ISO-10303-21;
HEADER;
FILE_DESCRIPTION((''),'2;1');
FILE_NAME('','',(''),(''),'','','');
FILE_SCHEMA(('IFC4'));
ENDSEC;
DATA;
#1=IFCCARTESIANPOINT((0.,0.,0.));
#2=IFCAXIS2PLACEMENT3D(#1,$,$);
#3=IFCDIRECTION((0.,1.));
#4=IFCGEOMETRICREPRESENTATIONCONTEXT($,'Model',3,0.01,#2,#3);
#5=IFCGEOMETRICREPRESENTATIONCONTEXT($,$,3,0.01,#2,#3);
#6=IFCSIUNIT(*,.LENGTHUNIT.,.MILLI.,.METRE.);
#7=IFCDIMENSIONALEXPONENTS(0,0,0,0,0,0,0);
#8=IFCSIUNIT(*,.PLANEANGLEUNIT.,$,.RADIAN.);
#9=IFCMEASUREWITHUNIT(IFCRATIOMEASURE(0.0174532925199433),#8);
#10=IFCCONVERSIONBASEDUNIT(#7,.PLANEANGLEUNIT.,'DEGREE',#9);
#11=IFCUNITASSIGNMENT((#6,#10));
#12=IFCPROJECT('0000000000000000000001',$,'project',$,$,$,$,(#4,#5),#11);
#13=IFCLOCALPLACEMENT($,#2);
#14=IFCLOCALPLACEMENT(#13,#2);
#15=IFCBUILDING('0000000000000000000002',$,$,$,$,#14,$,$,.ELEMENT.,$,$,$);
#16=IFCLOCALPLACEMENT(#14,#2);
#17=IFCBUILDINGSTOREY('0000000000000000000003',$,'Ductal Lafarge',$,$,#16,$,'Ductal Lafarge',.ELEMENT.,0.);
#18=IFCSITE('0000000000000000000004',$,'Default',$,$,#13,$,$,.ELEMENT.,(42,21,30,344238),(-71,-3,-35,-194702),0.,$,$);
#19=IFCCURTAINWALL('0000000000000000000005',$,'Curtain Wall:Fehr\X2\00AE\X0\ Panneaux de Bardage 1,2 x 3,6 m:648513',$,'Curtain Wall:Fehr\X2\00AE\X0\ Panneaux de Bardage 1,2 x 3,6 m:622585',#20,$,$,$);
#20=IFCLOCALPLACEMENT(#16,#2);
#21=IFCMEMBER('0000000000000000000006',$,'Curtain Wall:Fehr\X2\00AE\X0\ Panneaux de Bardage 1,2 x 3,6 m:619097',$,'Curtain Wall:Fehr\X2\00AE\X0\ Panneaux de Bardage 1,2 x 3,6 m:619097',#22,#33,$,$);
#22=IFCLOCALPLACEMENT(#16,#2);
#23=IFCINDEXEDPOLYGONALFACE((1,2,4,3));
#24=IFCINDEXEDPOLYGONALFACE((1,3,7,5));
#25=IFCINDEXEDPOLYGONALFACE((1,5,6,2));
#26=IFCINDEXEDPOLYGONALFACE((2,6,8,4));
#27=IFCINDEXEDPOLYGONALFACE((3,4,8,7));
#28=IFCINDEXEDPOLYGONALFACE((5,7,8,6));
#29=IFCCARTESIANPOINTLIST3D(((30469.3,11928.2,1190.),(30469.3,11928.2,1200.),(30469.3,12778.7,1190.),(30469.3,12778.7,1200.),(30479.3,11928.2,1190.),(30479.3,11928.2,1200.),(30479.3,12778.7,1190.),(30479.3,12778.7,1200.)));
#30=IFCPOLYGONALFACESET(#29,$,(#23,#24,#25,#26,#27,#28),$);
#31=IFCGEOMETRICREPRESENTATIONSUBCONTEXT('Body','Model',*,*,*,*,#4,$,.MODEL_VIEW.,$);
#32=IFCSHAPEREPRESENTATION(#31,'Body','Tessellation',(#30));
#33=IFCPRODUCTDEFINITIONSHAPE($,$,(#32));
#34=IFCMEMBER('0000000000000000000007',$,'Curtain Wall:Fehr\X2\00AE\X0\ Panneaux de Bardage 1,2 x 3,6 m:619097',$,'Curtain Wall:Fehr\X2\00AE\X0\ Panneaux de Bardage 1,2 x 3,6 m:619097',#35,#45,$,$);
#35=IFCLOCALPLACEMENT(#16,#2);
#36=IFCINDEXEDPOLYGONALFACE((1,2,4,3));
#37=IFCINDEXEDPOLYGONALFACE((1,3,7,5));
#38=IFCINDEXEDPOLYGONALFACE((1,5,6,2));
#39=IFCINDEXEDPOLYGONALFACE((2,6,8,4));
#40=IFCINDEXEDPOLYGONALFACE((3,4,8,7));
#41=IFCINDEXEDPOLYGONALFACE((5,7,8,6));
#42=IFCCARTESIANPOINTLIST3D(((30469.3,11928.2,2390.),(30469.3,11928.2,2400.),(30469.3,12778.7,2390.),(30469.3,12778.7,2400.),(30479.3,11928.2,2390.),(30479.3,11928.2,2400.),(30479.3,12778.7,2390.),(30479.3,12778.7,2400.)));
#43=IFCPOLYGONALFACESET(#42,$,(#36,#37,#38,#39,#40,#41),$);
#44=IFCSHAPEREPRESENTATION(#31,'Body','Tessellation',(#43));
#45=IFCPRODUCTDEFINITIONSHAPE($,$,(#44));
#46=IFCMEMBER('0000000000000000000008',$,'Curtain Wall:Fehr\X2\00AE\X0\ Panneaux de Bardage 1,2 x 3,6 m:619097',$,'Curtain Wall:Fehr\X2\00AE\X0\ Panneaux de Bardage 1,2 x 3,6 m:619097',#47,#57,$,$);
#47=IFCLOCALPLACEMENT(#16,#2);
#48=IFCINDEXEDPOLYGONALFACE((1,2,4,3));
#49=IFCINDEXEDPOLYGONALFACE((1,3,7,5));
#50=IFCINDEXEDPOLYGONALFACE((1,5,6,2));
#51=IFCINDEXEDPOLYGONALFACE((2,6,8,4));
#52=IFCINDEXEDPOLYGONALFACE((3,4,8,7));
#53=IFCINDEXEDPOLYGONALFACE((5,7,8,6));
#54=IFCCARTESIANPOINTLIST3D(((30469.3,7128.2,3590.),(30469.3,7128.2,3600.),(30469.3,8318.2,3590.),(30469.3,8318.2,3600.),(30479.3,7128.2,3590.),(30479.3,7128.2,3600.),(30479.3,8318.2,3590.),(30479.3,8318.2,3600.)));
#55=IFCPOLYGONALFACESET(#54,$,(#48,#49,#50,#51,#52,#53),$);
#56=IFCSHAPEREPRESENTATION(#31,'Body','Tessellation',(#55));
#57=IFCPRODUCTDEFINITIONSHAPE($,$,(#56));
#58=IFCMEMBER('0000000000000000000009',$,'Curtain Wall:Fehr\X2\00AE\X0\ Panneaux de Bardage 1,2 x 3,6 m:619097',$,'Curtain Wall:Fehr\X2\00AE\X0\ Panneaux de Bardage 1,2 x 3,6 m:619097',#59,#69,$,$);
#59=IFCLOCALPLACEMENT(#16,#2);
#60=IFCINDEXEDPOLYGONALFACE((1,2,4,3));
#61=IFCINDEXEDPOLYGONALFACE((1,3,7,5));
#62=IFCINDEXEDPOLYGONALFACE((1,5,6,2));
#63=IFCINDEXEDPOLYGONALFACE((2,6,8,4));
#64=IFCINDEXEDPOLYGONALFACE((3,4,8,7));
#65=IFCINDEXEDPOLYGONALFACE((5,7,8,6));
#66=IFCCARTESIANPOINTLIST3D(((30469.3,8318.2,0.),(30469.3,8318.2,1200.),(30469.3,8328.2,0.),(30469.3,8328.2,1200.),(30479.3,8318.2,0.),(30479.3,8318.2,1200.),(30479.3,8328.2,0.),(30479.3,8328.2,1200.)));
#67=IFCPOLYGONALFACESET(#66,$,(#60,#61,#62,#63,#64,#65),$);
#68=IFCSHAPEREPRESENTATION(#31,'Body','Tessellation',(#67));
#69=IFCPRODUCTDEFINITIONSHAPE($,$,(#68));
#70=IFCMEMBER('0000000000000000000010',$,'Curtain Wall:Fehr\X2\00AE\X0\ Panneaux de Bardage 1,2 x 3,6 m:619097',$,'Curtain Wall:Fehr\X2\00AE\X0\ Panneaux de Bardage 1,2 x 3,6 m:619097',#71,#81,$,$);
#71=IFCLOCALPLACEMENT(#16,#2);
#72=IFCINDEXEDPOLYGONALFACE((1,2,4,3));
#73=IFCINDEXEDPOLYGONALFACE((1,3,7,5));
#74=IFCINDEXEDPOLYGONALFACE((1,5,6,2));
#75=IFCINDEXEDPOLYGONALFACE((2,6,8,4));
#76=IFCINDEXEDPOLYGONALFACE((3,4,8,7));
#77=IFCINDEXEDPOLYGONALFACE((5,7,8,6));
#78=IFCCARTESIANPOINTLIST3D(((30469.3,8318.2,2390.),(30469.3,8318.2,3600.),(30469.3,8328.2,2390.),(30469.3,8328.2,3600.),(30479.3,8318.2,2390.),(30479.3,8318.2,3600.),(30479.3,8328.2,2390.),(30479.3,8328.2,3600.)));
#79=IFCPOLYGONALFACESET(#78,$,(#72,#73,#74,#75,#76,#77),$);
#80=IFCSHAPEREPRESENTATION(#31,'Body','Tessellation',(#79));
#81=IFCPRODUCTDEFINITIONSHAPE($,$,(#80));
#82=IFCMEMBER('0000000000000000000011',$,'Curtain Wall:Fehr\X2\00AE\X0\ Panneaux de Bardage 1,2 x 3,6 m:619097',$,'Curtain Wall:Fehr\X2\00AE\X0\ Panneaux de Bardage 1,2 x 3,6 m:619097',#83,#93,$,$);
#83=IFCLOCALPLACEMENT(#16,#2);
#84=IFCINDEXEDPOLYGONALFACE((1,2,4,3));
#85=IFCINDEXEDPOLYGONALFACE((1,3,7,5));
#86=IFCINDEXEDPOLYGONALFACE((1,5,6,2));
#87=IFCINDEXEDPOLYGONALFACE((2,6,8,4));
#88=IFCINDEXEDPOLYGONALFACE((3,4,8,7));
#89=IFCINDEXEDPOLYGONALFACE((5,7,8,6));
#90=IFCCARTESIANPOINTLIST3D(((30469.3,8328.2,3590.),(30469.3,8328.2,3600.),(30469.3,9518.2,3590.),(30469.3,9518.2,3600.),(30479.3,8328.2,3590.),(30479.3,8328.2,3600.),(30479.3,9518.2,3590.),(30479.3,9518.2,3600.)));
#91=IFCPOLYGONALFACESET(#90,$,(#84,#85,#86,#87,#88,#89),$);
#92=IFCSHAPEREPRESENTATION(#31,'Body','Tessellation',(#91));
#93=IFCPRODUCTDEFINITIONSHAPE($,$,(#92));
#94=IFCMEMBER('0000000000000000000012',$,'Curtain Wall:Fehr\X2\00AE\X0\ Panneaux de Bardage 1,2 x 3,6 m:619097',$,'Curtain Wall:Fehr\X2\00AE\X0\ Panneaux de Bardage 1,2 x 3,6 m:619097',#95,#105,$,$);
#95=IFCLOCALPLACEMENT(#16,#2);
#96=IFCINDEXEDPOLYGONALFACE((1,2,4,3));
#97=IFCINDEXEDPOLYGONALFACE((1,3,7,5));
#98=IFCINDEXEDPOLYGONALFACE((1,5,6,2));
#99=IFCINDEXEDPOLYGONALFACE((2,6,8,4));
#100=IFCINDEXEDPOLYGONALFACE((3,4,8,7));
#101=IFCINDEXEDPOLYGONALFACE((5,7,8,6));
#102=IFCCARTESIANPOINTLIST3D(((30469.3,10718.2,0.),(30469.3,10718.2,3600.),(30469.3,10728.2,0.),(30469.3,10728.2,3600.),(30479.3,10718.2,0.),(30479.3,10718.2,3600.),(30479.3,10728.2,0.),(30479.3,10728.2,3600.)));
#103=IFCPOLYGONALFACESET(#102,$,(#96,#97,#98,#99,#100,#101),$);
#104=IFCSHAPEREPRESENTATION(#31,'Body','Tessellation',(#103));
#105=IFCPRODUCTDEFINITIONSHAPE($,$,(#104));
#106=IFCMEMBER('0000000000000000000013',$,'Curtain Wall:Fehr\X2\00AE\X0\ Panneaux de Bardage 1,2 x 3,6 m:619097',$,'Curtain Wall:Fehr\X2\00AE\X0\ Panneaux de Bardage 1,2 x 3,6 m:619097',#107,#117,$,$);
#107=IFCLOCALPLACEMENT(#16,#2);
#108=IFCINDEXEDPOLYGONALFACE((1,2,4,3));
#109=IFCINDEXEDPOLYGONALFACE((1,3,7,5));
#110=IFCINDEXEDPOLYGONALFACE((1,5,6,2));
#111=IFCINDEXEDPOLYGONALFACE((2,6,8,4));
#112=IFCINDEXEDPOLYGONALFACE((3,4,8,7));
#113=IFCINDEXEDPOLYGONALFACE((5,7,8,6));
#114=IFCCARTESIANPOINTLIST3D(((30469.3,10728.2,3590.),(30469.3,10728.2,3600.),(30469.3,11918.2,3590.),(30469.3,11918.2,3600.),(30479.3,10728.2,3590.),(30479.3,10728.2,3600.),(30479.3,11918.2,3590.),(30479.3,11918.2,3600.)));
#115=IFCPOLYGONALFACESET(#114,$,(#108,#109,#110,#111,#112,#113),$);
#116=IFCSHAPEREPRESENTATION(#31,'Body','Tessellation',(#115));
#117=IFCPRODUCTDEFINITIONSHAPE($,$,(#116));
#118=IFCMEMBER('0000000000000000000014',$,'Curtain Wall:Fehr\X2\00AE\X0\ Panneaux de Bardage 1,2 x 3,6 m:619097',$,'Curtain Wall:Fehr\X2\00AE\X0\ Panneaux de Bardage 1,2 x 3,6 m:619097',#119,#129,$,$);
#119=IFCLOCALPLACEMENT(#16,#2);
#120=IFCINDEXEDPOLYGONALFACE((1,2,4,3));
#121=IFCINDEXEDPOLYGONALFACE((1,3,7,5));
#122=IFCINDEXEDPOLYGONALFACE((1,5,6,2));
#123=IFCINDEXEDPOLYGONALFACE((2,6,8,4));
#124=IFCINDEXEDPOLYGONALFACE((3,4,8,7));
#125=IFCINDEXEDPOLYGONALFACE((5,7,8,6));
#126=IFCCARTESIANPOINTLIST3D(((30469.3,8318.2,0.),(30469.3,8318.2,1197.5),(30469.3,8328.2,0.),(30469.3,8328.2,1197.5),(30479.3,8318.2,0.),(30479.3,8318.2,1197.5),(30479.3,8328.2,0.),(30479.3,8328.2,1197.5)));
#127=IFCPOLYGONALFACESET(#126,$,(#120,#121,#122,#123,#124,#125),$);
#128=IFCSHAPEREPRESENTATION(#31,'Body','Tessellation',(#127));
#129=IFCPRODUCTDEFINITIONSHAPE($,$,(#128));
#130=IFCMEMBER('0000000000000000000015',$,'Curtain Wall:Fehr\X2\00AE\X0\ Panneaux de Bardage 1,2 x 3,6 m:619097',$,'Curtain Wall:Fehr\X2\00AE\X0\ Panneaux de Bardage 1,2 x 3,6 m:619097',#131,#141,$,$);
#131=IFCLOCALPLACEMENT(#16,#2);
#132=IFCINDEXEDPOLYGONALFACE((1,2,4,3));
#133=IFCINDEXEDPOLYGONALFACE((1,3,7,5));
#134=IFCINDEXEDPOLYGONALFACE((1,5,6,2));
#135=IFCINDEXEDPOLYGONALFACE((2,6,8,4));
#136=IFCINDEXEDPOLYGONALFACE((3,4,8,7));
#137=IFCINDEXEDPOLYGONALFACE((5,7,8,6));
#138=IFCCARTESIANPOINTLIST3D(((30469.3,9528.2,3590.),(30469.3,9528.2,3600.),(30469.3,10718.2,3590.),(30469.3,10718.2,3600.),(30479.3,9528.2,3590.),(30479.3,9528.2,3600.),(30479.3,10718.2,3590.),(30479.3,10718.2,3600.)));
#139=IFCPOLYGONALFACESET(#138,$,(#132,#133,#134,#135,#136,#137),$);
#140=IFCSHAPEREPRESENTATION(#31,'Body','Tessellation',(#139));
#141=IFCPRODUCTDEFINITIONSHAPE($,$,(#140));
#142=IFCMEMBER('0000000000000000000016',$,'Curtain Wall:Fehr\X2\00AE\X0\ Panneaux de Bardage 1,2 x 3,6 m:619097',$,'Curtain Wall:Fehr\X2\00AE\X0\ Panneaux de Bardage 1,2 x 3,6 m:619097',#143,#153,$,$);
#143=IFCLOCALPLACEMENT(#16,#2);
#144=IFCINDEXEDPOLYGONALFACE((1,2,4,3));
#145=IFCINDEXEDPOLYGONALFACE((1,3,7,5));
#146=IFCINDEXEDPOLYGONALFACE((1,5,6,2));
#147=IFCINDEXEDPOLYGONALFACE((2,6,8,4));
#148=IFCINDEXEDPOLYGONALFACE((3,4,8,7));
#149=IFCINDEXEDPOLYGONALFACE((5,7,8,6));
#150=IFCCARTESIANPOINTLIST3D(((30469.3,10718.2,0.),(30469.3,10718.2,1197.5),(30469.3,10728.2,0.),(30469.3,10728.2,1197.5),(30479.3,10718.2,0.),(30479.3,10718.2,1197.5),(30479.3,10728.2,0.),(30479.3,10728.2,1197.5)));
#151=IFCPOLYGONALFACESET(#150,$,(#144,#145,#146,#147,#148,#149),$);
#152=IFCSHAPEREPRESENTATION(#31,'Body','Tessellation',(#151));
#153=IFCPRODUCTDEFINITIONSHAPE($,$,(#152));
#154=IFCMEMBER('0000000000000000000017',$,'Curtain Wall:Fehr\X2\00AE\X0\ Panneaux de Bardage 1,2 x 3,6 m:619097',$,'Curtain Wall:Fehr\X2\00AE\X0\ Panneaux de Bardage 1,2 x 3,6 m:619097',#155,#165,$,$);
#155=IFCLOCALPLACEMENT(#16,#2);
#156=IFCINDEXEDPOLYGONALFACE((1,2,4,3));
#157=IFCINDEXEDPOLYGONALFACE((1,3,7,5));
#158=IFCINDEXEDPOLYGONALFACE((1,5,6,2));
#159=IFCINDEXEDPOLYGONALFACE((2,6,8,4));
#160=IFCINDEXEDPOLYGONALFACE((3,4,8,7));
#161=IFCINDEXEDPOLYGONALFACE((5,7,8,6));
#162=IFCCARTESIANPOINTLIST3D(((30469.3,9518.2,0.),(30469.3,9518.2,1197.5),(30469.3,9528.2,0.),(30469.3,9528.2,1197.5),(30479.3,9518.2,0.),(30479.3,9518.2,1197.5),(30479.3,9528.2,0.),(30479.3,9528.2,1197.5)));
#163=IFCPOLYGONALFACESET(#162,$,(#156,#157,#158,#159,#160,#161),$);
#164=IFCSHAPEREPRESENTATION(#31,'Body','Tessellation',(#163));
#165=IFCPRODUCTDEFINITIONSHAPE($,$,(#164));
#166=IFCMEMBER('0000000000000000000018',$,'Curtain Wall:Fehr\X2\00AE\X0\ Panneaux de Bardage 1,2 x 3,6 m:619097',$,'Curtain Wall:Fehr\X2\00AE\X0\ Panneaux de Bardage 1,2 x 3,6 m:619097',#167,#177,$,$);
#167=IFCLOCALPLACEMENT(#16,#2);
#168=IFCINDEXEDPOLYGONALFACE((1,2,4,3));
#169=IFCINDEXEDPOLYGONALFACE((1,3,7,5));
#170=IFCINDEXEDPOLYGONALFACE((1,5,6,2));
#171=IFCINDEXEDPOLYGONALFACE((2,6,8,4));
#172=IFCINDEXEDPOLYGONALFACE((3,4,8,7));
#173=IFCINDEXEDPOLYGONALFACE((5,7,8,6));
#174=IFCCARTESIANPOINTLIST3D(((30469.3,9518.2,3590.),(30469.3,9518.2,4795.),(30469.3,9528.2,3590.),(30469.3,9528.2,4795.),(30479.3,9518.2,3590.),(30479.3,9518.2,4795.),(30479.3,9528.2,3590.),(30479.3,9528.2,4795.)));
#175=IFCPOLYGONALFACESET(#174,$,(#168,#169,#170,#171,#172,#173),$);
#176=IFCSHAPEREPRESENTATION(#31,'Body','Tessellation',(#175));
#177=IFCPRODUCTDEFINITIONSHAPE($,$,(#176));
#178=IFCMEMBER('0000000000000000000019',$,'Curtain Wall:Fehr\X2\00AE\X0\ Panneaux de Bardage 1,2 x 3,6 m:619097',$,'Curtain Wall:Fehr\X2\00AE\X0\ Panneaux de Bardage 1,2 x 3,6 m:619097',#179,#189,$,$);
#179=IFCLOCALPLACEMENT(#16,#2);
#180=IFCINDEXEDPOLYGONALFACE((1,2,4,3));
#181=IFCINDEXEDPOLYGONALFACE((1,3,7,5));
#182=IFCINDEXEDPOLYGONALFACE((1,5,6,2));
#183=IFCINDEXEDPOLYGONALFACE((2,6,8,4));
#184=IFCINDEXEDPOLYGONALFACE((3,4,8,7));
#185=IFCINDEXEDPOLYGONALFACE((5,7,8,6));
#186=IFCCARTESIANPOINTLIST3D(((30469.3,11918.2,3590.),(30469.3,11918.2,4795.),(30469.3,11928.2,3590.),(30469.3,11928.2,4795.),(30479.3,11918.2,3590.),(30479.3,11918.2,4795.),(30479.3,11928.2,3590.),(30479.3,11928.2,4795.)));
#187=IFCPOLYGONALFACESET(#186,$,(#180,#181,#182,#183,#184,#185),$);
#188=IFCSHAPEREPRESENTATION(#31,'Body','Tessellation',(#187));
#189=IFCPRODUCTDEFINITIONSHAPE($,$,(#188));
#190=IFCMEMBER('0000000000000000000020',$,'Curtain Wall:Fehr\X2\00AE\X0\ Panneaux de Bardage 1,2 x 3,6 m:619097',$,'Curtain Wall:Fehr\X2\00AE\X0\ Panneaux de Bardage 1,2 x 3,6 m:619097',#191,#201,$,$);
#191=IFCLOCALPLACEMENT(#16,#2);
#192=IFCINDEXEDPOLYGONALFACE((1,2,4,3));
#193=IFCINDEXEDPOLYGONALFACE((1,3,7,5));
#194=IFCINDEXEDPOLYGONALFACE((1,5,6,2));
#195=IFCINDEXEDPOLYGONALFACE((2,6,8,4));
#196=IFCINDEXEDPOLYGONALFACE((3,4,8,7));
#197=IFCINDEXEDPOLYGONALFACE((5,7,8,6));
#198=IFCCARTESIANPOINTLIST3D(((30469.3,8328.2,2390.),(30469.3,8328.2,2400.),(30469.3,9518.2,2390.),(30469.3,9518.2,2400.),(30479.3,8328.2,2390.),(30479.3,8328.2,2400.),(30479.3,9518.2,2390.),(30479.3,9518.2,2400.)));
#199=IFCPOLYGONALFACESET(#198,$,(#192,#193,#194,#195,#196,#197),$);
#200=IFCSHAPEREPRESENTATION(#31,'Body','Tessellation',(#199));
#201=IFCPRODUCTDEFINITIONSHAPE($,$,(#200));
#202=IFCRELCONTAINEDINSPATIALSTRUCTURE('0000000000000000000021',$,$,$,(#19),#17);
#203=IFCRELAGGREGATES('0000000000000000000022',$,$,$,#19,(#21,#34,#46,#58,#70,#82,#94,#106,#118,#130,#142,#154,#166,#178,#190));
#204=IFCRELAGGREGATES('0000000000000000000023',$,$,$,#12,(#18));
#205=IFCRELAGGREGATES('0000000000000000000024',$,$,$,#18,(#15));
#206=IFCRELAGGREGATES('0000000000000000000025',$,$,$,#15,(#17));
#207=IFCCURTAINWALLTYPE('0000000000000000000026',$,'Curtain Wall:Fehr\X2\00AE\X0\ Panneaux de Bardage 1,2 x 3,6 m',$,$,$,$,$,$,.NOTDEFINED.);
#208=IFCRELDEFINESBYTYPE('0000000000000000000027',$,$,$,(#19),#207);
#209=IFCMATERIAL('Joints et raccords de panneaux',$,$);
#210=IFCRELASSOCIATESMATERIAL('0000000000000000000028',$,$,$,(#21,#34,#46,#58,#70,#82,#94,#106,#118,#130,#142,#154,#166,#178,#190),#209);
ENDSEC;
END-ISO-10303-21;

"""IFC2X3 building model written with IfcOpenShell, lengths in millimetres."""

from ifc_helpers import new_model, entity, si_unit, converted_unit, direction, frame, frame_2d, origin, origin_2d_with_axis, place, context, subcontext, project, spatial, rectangle, extrude, material, type_object, element, aggregate, save


model = new_model("IFC2X3")

# Units and contexts
model_context = context("Model", 3, precision=0.01, world=origin(), true_north=direction((0.0, 1.0)))
context_of_model = context(None, 3, precision=0.01, world=origin(), true_north=direction((0.0, 1.0)))
body_context = subcontext(model_context, "Body", "Model", "MODEL_VIEW")
ifc_project = project(units=[si_unit("LENGTHUNIT", "METRE", prefix="MILLI"), converted_unit("PLANEANGLEUNIT", "DEGREE", entity("IfcRatioMeasure", 0.0174532925199433), si_unit("PLANEANGLEUNIT", "RADIAN"), dimensions=[0, 0, 0, 0, 0, 0, 0])], contexts=[model_context, context_of_model])

# Site, building, storey
site_placement = place(None, origin())
site = spatial("IfcSite", under=ifc_project, at=site_placement, Name="Default", CompositionType="ELEMENT", RefLatitude=(42, 21, 30, 344238), RefLongitude=(-71, -3, -35, -194702), RefElevation=0.0)
building_placement = place(site_placement, origin())
building = spatial("IfcBuilding", under=site, at=building_placement, CompositionType="ELEMENT")
storey_placement = place(building_placement, origin())
storey = spatial("IfcBuildingStorey", under=building, at=storey_placement, Name="Ductal Lafarge", LongName="Ductal Lafarge", CompositionType="ELEMENT", Elevation=0.0)

# Curtain wall, members
curtain_wall_type = type_object("IfcCurtainWallType", Name="Curtain Wall:Fehr® Panneaux de Bardage 1,2 x 3,6 m", PredefinedType="NOTDEFINED")
curtain_wall_placement = place(storey_placement, origin())
curtain_wall = element("IfcCurtainWall", 1, at=curtain_wall_placement, inside=storey, type_object=curtain_wall_type, Name="Curtain Wall:Fehr® Panneaux de Bardage 1,2 x 3,6 m:648513", ObjectType="Curtain Wall:Fehr® Panneaux de Bardage 1,2 x 3,6 m:622585")
ifc_material_1 = material(Name="Joints et raccords de panneaux")
member_1_placement = place(curtain_wall_placement, frame((30469.3, 11928.2, 1190.0)))
member_1 = element("IfcMember", 2, at=member_1_placement, material=ifc_material_1, Name="Curtain Wall:Fehr® Panneaux de Bardage 1,2 x 3,6 m:619097", ObjectType="Curtain Wall:Fehr® Panneaux de Bardage 1,2 x 3,6 m:619097", context=body_context, shape_type="SweptSolid", body=[
    extrude(rectangle(XDim=850.5, YDim=10.0, at=origin_2d_with_axis()), frame((5.0, 425.2, 0.0), z_axis=(0.0, 0.0, 1.0), x_axis=(0.0, -1.0, 0.0)), (0.0, 0.0, 1.0), 10.0),
])
member_2_placement = place(curtain_wall_placement, frame((30469.3, 11928.2, 2390.0)))
member_2 = element("IfcMember", 3, at=member_2_placement, material=ifc_material_1, Name="Curtain Wall:Fehr® Panneaux de Bardage 1,2 x 3,6 m:619097", ObjectType="Curtain Wall:Fehr® Panneaux de Bardage 1,2 x 3,6 m:619097", context=body_context, shape_type="SweptSolid", body=[
    extrude(rectangle(XDim=850.5, YDim=10.0, at=origin_2d_with_axis()), frame((5.0, 425.2, 0.0), z_axis=(0.0, 0.0, 1.0), x_axis=(0.0, -1.0, 0.0)), (0.0, 0.0, 1.0), 10.0),
])
member_3_placement = place(curtain_wall_placement, frame((30469.3, 7128.2, 3590.0)))
member_3 = element("IfcMember", 4, at=member_3_placement, material=ifc_material_1, Name="Curtain Wall:Fehr® Panneaux de Bardage 1,2 x 3,6 m:619097", ObjectType="Curtain Wall:Fehr® Panneaux de Bardage 1,2 x 3,6 m:619097", context=body_context, shape_type="SweptSolid", body=[
    extrude(rectangle(XDim=1190.0, YDim=10.0, at=origin_2d_with_axis()), frame((5.0, 595.0, 0.0), z_axis=(0.0, 0.0, 1.0), x_axis=(0.0, -1.0, 0.0)), (0.0, 0.0, 1.0), 10.0),
])
member_4_placement = place(curtain_wall_placement, frame((30469.3, 8318.2, 0.0)))
member_4 = element("IfcMember", 5, at=member_4_placement, material=ifc_material_1, Name="Curtain Wall:Fehr® Panneaux de Bardage 1,2 x 3,6 m:619097", ObjectType="Curtain Wall:Fehr® Panneaux de Bardage 1,2 x 3,6 m:619097", context=body_context, shape_type="SweptSolid", body=[
    extrude(rectangle(XDim=10.0, YDim=10.0, at=frame_2d((0.0, 0.0), x_axis=(1.0, 0.0))), frame((5.0, 5.0, 0.0), z_axis=(0.0, 0.0, 1.0), x_axis=(-1.0, 0.0, 0.0)), (0.0, 0.0, 1.0), 1200.0),
])
member_5_placement = place(curtain_wall_placement, frame((30469.3, 8318.2, 2390.0)))
member_5 = element("IfcMember", 6, at=member_5_placement, material=ifc_material_1, Name="Curtain Wall:Fehr® Panneaux de Bardage 1,2 x 3,6 m:619097", ObjectType="Curtain Wall:Fehr® Panneaux de Bardage 1,2 x 3,6 m:619097", context=body_context, shape_type="SweptSolid", body=[
    extrude(rectangle(XDim=10.0, YDim=10.0, at=frame_2d((0.0, 0.0), x_axis=(1.0, 0.0))), frame((5.0, 5.0, 0.0), z_axis=(0.0, 0.0, 1.0), x_axis=(-1.0, 0.0, 0.0)), (0.0, 0.0, 1.0), 1210.0),
])
member_6_placement = place(curtain_wall_placement, frame((30469.3, 8328.2, 3590.0)))
member_6 = element("IfcMember", 7, at=member_6_placement, material=ifc_material_1, Name="Curtain Wall:Fehr® Panneaux de Bardage 1,2 x 3,6 m:619097", ObjectType="Curtain Wall:Fehr® Panneaux de Bardage 1,2 x 3,6 m:619097", context=body_context, shape_type="SweptSolid", body=[
    extrude(rectangle(XDim=1190.0, YDim=10.0, at=frame_2d((0.0, 0.0), x_axis=(1.0, 0.0))), frame((5.0, 595.0, 0.0), z_axis=(0.0, 0.0, 1.0), x_axis=(0.0, -1.0, 0.0)), (0.0, 0.0, 1.0), 10.0),
])
member_7_placement = place(curtain_wall_placement, frame((30469.3, 10718.2, 0.0)))
member_7 = element("IfcMember", 8, at=member_7_placement, material=ifc_material_1, Name="Curtain Wall:Fehr® Panneaux de Bardage 1,2 x 3,6 m:619097", ObjectType="Curtain Wall:Fehr® Panneaux de Bardage 1,2 x 3,6 m:619097", context=body_context, shape_type="SweptSolid", body=[
    extrude(rectangle(XDim=10.0, YDim=10.0, at=frame_2d((0.0, 0.0), x_axis=(1.0, 0.0))), frame((5.0, 5.0, 0.0), z_axis=(0.0, 0.0, 1.0), x_axis=(-1.0, 0.0, 0.0)), (0.0, 0.0, 1.0), 3600.0),
])
member_8_placement = place(curtain_wall_placement, frame((30469.3, 10728.2, 3590.0)))
member_8 = element("IfcMember", 9, at=member_8_placement, material=ifc_material_1, Name="Curtain Wall:Fehr® Panneaux de Bardage 1,2 x 3,6 m:619097", ObjectType="Curtain Wall:Fehr® Panneaux de Bardage 1,2 x 3,6 m:619097", context=body_context, shape_type="SweptSolid", body=[
    extrude(rectangle(XDim=1190.0, YDim=10.0, at=frame_2d((0.0, 0.0), x_axis=(1.0, 0.0))), frame((5.0, 595.0, 0.0), z_axis=(0.0, 0.0, 1.0), x_axis=(0.0, -1.0, 0.0)), (0.0, 0.0, 1.0), 10.0),
])
member_9_placement = place(curtain_wall_placement, frame((30469.3, 8318.2, 0.0)))
member_9 = element("IfcMember", 10, at=member_9_placement, material=ifc_material_1, Name="Curtain Wall:Fehr® Panneaux de Bardage 1,2 x 3,6 m:619097", ObjectType="Curtain Wall:Fehr® Panneaux de Bardage 1,2 x 3,6 m:619097", context=body_context, shape_type="SweptSolid", body=[
    extrude(rectangle(XDim=10.0, YDim=10.0, at=frame_2d((0.0, 0.0), x_axis=(1.0, 0.0))), frame((5.0, 5.0, 0.0), z_axis=(0.0, 0.0, 1.0), x_axis=(-1.0, 0.0, 0.0)), (0.0, 0.0, 1.0), 1197.5),
])
member_10_placement = place(curtain_wall_placement, frame((30469.3, 9528.2, 3590.0)))
member_10 = element("IfcMember", 11, at=member_10_placement, material=ifc_material_1, Name="Curtain Wall:Fehr® Panneaux de Bardage 1,2 x 3,6 m:619097", ObjectType="Curtain Wall:Fehr® Panneaux de Bardage 1,2 x 3,6 m:619097", context=body_context, shape_type="SweptSolid", body=[
    extrude(rectangle(XDim=1190.0, YDim=10.0, at=frame_2d((0.0, 0.0), x_axis=(1.0, 0.0))), frame((5.0, 595.0, 0.0), z_axis=(0.0, 0.0, 1.0), x_axis=(0.0, -1.0, 0.0)), (0.0, 0.0, 1.0), 10.0),
])
member_11_placement = place(curtain_wall_placement, frame((30469.3, 10718.2, 0.0)))
member_11 = element("IfcMember", 12, at=member_11_placement, material=ifc_material_1, Name="Curtain Wall:Fehr® Panneaux de Bardage 1,2 x 3,6 m:619097", ObjectType="Curtain Wall:Fehr® Panneaux de Bardage 1,2 x 3,6 m:619097", context=body_context, shape_type="SweptSolid", body=[
    extrude(rectangle(XDim=10.0, YDim=10.0, at=frame_2d((0.0, 0.0), x_axis=(1.0, 0.0))), frame((5.0, 5.0, 0.0), z_axis=(0.0, 0.0, 1.0), x_axis=(-1.0, 0.0, 0.0)), (0.0, 0.0, 1.0), 1197.5),
])
member_12_placement = place(curtain_wall_placement, frame((30469.3, 9518.2, 0.0)))
member_12 = element("IfcMember", 13, at=member_12_placement, material=ifc_material_1, Name="Curtain Wall:Fehr® Panneaux de Bardage 1,2 x 3,6 m:619097", ObjectType="Curtain Wall:Fehr® Panneaux de Bardage 1,2 x 3,6 m:619097", context=body_context, shape_type="SweptSolid", body=[
    extrude(rectangle(XDim=10.0, YDim=10.0, at=frame_2d((0.0, 0.0), x_axis=(1.0, 0.0))), frame((5.0, 5.0, 0.0), z_axis=(0.0, 0.0, 1.0), x_axis=(-1.0, 0.0, 0.0)), (0.0, 0.0, 1.0), 1197.5),
])
member_13_placement = place(curtain_wall_placement, frame((30469.3, 9518.2, 3590.0)))
member_13 = element("IfcMember", 14, at=member_13_placement, material=ifc_material_1, Name="Curtain Wall:Fehr® Panneaux de Bardage 1,2 x 3,6 m:619097", ObjectType="Curtain Wall:Fehr® Panneaux de Bardage 1,2 x 3,6 m:619097", context=body_context, shape_type="SweptSolid", body=[
    extrude(rectangle(XDim=10.0, YDim=10.0, at=frame_2d((0.0, 0.0), x_axis=(1.0, 0.0))), frame((5.0, 5.0, 0.0), z_axis=(0.0, 0.0, 1.0), x_axis=(-1.0, 0.0, 0.0)), (0.0, 0.0, 1.0), 1205.0),
])
member_14_placement = place(curtain_wall_placement, frame((30469.3, 11918.2, 3590.0)))
member_14 = element("IfcMember", 15, at=member_14_placement, material=ifc_material_1, Name="Curtain Wall:Fehr® Panneaux de Bardage 1,2 x 3,6 m:619097", ObjectType="Curtain Wall:Fehr® Panneaux de Bardage 1,2 x 3,6 m:619097", context=body_context, shape_type="SweptSolid", body=[
    extrude(rectangle(XDim=10.0, YDim=10.0, at=frame_2d((0.0, 0.0), x_axis=(1.0, 0.0))), frame((5.0, 5.0, 0.0), z_axis=(0.0, 0.0, 1.0), x_axis=(-1.0, 0.0, 0.0)), (0.0, 0.0, 1.0), 1205.0),
])
member_15_placement = place(curtain_wall_placement, frame((30469.3, 8328.2, 2390.0)))
member_15 = element("IfcMember", 16, at=member_15_placement, material=ifc_material_1, Name="Curtain Wall:Fehr® Panneaux de Bardage 1,2 x 3,6 m:619097", ObjectType="Curtain Wall:Fehr® Panneaux de Bardage 1,2 x 3,6 m:619097", context=body_context, shape_type="SweptSolid", body=[
    extrude(rectangle(XDim=1190.0, YDim=10.0, at=frame_2d((0.0, 0.0), x_axis=(1.0, 0.0))), frame((5.0, 595.0, 0.0), z_axis=(0.0, 0.0, 1.0), x_axis=(0.0, -1.0, 0.0)), (0.0, 0.0, 1.0), 10.0),
])
aggregate(curtain_wall, [member_1, member_2, member_3, member_4, member_5, member_6, member_7, member_8, member_9, member_10, member_11, member_12, member_13, member_14, member_15])

save(model, "model.ifc")
